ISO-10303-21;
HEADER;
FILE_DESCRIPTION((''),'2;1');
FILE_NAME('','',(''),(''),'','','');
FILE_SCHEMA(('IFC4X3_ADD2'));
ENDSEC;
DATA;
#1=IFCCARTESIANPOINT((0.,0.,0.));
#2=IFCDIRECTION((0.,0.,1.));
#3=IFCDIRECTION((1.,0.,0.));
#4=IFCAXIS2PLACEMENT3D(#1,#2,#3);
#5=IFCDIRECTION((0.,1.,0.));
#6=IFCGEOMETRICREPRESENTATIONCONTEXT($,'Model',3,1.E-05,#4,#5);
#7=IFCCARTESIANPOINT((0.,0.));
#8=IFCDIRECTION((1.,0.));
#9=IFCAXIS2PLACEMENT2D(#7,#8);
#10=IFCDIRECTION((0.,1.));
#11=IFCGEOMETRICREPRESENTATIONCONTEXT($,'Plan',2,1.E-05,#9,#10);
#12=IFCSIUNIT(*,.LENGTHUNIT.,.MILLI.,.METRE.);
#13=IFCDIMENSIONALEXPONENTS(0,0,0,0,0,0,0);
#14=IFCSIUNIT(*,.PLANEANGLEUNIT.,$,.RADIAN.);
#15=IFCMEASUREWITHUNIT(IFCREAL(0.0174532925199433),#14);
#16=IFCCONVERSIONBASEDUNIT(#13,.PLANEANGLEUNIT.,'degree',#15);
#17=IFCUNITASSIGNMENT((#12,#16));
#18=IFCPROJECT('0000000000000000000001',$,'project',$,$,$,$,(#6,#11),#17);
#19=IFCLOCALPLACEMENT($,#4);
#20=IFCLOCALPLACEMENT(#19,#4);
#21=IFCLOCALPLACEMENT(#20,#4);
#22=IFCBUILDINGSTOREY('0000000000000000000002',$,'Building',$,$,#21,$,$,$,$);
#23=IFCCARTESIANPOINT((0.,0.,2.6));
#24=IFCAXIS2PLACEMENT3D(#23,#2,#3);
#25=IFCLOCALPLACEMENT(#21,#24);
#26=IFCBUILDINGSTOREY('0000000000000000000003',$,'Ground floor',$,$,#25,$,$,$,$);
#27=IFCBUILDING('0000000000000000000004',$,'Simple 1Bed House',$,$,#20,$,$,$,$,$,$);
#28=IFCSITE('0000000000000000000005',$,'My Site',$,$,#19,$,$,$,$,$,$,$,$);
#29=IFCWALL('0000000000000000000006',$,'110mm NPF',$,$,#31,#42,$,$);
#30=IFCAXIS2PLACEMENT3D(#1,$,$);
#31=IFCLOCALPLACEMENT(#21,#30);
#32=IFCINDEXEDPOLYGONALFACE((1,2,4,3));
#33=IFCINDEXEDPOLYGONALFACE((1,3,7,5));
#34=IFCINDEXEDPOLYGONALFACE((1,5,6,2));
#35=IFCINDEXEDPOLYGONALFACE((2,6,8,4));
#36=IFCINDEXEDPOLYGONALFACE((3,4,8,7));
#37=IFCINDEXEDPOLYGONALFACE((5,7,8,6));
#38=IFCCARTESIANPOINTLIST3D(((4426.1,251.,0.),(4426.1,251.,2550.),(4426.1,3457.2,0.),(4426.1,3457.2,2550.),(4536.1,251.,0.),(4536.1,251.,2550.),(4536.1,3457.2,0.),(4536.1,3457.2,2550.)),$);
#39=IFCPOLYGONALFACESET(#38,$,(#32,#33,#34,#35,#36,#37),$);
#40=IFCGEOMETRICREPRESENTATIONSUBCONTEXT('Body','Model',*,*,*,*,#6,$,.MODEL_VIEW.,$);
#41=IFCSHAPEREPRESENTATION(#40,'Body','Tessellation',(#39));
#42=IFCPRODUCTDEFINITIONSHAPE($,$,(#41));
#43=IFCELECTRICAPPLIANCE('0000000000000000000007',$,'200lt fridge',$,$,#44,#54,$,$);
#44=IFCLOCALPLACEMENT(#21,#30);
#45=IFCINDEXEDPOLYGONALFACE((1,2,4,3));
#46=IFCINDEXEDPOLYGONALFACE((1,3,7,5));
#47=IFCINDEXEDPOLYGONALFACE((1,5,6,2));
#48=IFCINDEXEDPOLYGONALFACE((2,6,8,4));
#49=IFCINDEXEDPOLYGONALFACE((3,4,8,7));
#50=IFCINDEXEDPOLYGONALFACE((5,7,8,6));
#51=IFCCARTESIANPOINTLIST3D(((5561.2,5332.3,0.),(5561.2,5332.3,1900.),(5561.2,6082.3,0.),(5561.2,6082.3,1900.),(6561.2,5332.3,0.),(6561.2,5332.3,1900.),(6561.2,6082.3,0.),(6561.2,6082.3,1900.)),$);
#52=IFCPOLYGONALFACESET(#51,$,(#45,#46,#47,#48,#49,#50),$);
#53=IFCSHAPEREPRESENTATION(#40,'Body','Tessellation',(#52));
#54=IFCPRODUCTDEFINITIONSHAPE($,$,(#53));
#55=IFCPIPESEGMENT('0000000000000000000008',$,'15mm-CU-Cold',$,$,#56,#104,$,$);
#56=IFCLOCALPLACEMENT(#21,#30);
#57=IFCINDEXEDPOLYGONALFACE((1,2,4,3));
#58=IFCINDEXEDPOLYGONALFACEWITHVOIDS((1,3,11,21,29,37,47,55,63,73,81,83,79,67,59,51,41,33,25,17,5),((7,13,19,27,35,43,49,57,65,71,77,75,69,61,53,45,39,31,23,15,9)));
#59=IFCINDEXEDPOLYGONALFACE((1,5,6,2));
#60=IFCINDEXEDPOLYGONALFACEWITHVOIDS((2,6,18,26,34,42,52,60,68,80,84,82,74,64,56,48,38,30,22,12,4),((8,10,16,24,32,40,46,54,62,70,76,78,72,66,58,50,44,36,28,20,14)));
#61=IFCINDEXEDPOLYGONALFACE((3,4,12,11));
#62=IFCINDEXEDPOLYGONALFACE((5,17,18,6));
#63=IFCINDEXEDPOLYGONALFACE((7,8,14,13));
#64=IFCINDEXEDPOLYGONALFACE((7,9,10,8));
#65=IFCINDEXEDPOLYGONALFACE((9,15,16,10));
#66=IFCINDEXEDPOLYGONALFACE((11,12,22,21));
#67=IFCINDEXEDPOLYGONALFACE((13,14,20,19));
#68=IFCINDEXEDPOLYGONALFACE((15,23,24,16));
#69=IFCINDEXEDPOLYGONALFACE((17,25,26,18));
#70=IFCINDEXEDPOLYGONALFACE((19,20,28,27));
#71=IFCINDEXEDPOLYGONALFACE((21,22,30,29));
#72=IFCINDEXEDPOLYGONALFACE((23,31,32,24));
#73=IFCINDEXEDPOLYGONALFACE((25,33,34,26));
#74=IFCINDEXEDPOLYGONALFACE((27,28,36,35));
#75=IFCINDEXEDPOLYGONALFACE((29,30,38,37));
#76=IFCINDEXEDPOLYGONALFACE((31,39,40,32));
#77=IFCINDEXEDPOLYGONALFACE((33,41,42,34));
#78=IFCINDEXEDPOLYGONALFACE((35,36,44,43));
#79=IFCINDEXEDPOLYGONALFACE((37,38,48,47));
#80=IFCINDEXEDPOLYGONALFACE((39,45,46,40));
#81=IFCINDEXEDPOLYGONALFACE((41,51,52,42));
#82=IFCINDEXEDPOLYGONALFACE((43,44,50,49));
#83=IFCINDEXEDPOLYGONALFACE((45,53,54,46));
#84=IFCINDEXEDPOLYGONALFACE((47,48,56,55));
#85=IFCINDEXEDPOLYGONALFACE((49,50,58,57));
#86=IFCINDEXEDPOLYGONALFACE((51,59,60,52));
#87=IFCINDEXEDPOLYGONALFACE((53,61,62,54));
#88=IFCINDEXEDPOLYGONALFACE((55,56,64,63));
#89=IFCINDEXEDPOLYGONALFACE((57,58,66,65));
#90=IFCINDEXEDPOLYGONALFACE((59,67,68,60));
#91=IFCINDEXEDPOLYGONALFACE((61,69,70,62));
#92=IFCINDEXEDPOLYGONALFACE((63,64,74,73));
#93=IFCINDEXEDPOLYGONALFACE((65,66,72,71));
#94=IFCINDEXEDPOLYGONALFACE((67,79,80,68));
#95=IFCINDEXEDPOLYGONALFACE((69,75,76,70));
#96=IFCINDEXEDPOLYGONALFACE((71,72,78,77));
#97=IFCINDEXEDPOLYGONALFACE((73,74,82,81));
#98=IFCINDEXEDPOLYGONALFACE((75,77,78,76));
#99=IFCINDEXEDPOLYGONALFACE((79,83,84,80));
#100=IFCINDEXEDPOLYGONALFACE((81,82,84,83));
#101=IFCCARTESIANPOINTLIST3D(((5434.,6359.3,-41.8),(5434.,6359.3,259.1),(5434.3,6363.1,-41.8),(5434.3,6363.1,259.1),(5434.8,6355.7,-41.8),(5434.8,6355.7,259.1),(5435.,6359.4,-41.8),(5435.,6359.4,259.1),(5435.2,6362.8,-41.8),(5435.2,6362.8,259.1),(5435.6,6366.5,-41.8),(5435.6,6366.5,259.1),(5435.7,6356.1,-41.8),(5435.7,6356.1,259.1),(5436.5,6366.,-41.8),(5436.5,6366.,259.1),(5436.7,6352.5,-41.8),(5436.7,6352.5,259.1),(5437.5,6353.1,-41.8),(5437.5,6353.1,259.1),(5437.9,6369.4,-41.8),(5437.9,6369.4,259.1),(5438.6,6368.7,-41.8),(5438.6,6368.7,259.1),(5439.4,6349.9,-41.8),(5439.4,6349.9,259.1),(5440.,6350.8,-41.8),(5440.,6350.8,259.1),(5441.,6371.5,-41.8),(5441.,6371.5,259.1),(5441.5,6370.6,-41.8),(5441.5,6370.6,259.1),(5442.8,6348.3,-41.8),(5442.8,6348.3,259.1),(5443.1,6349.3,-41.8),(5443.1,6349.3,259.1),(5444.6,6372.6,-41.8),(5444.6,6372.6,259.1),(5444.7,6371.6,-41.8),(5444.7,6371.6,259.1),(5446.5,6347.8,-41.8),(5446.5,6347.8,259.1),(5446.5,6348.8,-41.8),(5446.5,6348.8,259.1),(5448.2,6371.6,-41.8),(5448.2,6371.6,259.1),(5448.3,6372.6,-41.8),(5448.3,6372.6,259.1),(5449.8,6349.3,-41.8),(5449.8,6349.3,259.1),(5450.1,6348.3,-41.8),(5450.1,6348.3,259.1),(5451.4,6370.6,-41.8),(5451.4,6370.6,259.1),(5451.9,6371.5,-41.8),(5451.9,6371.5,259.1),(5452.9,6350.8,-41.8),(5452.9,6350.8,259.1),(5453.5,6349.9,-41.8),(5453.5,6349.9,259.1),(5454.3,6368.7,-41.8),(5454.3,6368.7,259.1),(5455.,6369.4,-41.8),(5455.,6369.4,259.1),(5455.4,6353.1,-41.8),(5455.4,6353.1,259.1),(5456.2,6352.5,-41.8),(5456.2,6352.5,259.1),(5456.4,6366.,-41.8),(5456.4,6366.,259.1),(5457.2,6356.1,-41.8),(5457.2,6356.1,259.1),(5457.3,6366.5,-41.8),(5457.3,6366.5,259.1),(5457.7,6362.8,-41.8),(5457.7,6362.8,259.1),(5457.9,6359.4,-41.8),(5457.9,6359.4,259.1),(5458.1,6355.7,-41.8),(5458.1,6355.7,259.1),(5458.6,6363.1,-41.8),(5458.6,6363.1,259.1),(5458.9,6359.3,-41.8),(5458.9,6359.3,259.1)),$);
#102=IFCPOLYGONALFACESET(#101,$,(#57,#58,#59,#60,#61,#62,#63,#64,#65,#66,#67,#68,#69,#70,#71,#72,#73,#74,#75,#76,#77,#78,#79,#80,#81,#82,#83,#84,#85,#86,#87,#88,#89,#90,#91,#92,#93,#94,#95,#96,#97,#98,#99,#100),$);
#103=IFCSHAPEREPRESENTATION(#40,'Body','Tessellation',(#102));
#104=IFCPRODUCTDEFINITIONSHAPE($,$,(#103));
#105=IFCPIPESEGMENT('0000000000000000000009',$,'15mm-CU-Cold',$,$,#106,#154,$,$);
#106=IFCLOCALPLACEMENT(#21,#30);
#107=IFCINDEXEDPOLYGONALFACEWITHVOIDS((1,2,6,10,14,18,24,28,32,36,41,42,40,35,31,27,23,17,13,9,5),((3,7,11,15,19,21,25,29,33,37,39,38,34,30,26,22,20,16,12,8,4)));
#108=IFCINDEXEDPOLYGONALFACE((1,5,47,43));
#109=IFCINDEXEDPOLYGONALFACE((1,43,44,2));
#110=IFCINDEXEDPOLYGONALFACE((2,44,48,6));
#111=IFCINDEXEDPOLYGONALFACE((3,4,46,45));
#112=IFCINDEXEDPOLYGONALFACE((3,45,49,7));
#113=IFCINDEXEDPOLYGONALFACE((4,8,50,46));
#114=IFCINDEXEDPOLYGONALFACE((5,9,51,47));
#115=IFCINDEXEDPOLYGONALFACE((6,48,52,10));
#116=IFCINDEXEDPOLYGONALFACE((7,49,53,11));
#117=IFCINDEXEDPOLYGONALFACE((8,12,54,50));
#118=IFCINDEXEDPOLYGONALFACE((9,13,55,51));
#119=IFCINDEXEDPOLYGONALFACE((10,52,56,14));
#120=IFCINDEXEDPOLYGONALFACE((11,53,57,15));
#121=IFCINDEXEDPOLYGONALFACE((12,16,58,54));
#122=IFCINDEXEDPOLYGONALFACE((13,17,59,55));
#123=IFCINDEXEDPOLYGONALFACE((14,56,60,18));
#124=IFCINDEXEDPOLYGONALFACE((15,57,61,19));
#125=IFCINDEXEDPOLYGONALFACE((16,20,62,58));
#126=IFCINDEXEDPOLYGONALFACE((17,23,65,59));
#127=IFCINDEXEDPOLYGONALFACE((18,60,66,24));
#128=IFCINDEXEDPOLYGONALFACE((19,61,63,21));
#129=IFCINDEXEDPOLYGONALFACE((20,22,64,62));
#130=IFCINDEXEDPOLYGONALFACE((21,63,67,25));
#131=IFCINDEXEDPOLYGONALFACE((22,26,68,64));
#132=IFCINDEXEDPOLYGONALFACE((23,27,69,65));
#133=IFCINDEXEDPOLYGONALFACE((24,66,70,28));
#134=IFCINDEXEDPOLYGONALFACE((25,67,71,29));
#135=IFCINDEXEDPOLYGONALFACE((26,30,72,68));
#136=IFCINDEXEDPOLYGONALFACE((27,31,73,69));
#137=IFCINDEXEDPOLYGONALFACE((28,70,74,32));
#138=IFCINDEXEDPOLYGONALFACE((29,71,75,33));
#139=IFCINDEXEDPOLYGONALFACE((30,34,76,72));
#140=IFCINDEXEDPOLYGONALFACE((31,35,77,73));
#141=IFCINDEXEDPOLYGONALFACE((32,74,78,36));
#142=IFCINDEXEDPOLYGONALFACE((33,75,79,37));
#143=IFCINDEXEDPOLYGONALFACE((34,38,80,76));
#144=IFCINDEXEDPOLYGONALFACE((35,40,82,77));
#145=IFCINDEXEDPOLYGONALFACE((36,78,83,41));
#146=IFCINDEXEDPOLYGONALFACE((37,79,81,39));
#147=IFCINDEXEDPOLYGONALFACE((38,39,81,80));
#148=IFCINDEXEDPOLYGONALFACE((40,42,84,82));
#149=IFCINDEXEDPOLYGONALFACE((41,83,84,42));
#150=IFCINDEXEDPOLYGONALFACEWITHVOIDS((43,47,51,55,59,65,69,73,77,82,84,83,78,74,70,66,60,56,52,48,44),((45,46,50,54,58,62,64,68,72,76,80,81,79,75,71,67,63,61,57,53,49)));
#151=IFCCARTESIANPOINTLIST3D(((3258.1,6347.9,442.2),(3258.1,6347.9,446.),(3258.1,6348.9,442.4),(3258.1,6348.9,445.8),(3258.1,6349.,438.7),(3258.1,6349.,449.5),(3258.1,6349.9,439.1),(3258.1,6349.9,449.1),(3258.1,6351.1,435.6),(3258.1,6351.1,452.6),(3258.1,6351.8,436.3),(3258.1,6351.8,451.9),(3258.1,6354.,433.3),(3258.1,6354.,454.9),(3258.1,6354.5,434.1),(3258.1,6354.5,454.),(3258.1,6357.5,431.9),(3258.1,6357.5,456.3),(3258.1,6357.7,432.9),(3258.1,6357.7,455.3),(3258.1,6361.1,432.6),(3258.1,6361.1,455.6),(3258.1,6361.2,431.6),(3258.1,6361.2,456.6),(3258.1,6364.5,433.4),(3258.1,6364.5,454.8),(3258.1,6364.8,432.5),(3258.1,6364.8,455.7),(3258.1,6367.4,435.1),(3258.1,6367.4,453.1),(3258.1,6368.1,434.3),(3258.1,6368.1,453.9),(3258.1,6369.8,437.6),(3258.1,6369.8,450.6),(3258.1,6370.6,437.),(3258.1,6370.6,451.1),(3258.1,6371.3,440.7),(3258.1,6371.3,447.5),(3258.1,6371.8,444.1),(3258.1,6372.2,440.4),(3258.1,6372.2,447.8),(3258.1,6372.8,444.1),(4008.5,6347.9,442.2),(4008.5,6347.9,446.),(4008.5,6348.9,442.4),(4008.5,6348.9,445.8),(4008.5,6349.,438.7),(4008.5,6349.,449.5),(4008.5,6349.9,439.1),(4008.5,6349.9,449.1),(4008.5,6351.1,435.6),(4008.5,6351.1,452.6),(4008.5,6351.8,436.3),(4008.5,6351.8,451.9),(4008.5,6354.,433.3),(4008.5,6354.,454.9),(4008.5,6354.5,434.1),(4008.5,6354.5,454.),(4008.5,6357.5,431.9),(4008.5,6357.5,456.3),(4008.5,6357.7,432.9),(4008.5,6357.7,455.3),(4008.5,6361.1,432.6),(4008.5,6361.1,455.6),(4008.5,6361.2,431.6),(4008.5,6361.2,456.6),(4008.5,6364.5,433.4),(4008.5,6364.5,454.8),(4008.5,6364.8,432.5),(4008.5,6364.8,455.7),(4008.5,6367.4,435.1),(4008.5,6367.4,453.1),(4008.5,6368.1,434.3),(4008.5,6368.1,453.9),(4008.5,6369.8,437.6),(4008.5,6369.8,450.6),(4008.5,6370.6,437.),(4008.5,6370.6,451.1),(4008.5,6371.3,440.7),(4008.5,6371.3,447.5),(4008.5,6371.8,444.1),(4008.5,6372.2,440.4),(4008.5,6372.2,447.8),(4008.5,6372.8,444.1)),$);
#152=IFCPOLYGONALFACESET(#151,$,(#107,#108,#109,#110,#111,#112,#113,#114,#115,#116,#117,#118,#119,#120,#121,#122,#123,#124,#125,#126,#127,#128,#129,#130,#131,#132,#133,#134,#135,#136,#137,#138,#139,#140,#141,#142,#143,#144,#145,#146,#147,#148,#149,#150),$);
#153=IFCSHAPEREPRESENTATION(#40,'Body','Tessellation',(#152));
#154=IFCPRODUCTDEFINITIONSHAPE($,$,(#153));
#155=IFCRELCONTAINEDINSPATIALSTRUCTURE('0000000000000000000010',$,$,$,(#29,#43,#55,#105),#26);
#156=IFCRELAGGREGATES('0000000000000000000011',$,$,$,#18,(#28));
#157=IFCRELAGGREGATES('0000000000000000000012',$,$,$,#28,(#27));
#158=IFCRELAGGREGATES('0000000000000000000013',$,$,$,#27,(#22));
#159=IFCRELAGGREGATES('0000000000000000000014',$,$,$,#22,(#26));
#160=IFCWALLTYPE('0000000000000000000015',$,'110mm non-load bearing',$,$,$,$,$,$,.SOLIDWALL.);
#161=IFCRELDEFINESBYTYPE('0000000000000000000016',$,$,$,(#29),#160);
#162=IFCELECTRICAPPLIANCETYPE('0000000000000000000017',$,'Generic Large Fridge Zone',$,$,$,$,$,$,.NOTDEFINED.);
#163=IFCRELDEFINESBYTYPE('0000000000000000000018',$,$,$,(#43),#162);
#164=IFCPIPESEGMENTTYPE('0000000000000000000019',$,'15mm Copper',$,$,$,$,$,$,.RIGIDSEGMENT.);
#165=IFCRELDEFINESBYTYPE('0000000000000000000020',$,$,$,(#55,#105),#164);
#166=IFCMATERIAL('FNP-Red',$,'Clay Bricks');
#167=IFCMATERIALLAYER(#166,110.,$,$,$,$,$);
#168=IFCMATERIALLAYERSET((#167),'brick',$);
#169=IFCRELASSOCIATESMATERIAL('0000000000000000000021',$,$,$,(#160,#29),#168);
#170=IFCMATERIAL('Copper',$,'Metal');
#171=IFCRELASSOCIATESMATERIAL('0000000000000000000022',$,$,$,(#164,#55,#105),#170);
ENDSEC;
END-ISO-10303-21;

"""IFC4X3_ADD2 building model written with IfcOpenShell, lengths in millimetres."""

from ifc_helpers import new_model, entity, si_unit, converted_unit, direction, frame, origin_with_axes, origin_2d_with_axis, place, context, subcontext, project, spatial, line, indexed_curve, hollow_circle, outline, extrude, shape, source, transform, mapped, material, layer, layer_set, layer_usage, material_profile, profile_set, profile_usage, type_object, type_shapes, element, save


model = new_model("IFC4X3_ADD2")

# Units and contexts
model_context = context("Model", 3, precision=1e-05, world=origin_with_axes(), true_north=direction((0.0, 1.0, 0.0)))
plan_context = context("Plan", 2, precision=1e-05, world=origin_2d_with_axis(), true_north=direction((0.0, 1.0)))
body_context_1 = subcontext(model_context, "Body", "Model", "MODEL_VIEW")
body_context_2 = subcontext(plan_context, "Body", "Plan", "PLAN_VIEW")
ifc_project = project(units=[si_unit("LENGTHUNIT", "METRE", prefix="MILLI"), converted_unit("PLANEANGLEUNIT", "degree", entity("IfcReal", 0.0174532925199433), si_unit("PLANEANGLEUNIT", "RADIAN"), dimensions=[0, 0, 0, 0, 0, 0, 0])], contexts=[model_context, plan_context])

# Site, building, storeys
site_placement = place(None, origin_with_axes())
site = spatial("IfcSite", under=ifc_project, at=site_placement, Name="My Site")
building_placement = place(site_placement, origin_with_axes())
building = spatial("IfcBuilding", under=site, at=building_placement, Name="Simple 1Bed House")
storey_1_placement = place(building_placement, origin_with_axes())
storey_1 = spatial("IfcBuildingStorey", under=building, at=storey_1_placement, Name="Building")
storey_2_placement = place(storey_1_placement, frame((0.0, 0.0, 2.6), z_axis=(0.0, 0.0, 1.0), x_axis=(1.0, 0.0, 0.0)))
storey_2 = spatial("IfcBuildingStorey", under=storey_1, at=storey_2_placement, Name="Ground floor")

# Wall
ifc_material_1 = material(Name="FNP-Red", Category="Clay Bricks")
ifc_layer_1 = layer(ifc_material_1, 110.0)
ifc_layer_set_1 = layer_set([ifc_layer_1], Name="brick")
ifc_layer_usage_1 = layer_usage(ifc_layer_set_1, "AXIS2", "POSITIVE", 0.0)
wall_type_1 = type_object("IfcWallType", Name="110mm non-load bearing", PredefinedType="SOLIDWALL", material=ifc_layer_set_1)
wall_1_placement = place(storey_2_placement, frame((4536.1, 251.0, -2.6), z_axis=(0.0, 0.0, 1.0), x_axis=(-0.000001, 1.0, 0.0)))
element("IfcWall", 1, at=wall_1_placement, inside=storey_2, type_object=wall_type_1, material=ifc_layer_usage_1, Name="110mm NPF", context=body_context_1, shape_type="SweptSolid", body=[
    extrude(outline(indexed_curve([(0.0, 0.0), (0.0, 110.0), (3206.2, 110.0), (3206.2, 0.0), (0.0, 0.0)], self_intersect=False)), origin_with_axes(), (0.0, 0.0, 1.0), 2550.0),
])

# Electric appliance
electric_appliance_type = type_object("IfcElectricApplianceType", Name="Generic Large Fridge Zone", PredefinedType="NOTDEFINED")
shared_shape_1 = source(origin_with_axes(), body_context_1, "Body", "SweptSolid", [
    extrude(outline(indexed_curve([(0.0, 0.0), (1000.0, 0.0), (1000.0, 750.0), (0.0, 750.0)], segments=[line(1, 2, 3, 4, 1)])), origin_with_axes(), (0.0, 0.0, 1.0), 1900.0),
])
shared_shape_2 = source(origin_with_axes(), body_context_2, "Body", "Curve2D", [
    entity("IfcIndexedPolyCurve", entity("IfcCartesianPointList2D", [[0.0, 0.0], [1000.0, 0.0], [1000.0, 750.0], [0.0, 750.0]]), [entity("IfcLineIndex", [1, 2, 3, 4, 1])]),
])
type_shapes(electric_appliance_type, [shared_shape_1, shared_shape_2])
electric_appliance_placement = place(storey_2_placement, frame((5561.2, 5332.3, -2.6), z_axis=(0.0, 0.0, 1.0), x_axis=(1.0, 0.000001, 0.0)))
element("IfcElectricAppliance", 2, at=electric_appliance_placement, inside=storey_2, type_object=electric_appliance_type, Name="200lt fridge", shapes=[
    shape(body_context_1, "Body", "MappedRepresentation", [mapped(shared_shape_1, transform((0.0, 0.0, 0.0), x_axis=(1.0, 0.0, 0.0), y_axis=(0.0, 1.0, 0.0), z_axis=(0.0, 0.0, 1.0), scale=1.0))]),
    shape(body_context_2, "Body", "MappedRepresentation", [mapped(shared_shape_2, transform((0.0, 0.0, 0.0), x_axis=(1.0, 0.0, 0.0), y_axis=(0.0, 1.0, 0.0), z_axis=(0.0, 0.0, 1.0), scale=1.0))]),
])

# Pipe segments
ifc_material_2 = material(Name="Copper", Category="Metal")
ifc_material_profile = material_profile(ifc_material_2, hollow_circle(Radius=12.5, WallThickness=1.0))
ifc_profile_set = profile_set([ifc_material_profile])
ifc_profile_usage_1 = profile_usage(ifc_profile_set, cardinal=5)
pipe_segment_type = type_object("IfcPipeSegmentType", Name="15mm Copper", PredefinedType="RIGIDSEGMENT", material=ifc_profile_set)
pipe_segment_1_placement = place(storey_2_placement, frame((5446.5, 6360.3, -44.4), z_axis=(0.0, 0.0, 1.0), x_axis=(0.0, -1.0, 0.0)))
element("IfcPipeSegment", 3, at=pipe_segment_1_placement, inside=storey_2, type_object=pipe_segment_type, material=ifc_profile_usage_1, Name="15mm-CU-Cold", context=body_context_1, shape_type="SweptSolid", body=[
    extrude(hollow_circle(Radius=12.5, WallThickness=1.0), origin_with_axes(), (0.0, 0.0, 1.0), 300.9),
])
ifc_profile_usage_2 = profile_usage(ifc_profile_set, cardinal=5)
pipe_segment_2_placement = place(storey_2_placement, frame((3258.1, 6360.3, 441.5), z_axis=(1.0, 0.0, 0.0), x_axis=(0.0, 1.0, 0.0)))
element("IfcPipeSegment", 4, at=pipe_segment_2_placement, inside=storey_2, type_object=pipe_segment_type, material=ifc_profile_usage_2, Name="15mm-CU-Cold", context=body_context_1, shape_type="SweptSolid", body=[
    extrude(hollow_circle(Radius=12.5, WallThickness=1.0), origin_with_axes(), (0.0, 0.0, 1.0), 750.4),
])

save(model, "model.ifc")
